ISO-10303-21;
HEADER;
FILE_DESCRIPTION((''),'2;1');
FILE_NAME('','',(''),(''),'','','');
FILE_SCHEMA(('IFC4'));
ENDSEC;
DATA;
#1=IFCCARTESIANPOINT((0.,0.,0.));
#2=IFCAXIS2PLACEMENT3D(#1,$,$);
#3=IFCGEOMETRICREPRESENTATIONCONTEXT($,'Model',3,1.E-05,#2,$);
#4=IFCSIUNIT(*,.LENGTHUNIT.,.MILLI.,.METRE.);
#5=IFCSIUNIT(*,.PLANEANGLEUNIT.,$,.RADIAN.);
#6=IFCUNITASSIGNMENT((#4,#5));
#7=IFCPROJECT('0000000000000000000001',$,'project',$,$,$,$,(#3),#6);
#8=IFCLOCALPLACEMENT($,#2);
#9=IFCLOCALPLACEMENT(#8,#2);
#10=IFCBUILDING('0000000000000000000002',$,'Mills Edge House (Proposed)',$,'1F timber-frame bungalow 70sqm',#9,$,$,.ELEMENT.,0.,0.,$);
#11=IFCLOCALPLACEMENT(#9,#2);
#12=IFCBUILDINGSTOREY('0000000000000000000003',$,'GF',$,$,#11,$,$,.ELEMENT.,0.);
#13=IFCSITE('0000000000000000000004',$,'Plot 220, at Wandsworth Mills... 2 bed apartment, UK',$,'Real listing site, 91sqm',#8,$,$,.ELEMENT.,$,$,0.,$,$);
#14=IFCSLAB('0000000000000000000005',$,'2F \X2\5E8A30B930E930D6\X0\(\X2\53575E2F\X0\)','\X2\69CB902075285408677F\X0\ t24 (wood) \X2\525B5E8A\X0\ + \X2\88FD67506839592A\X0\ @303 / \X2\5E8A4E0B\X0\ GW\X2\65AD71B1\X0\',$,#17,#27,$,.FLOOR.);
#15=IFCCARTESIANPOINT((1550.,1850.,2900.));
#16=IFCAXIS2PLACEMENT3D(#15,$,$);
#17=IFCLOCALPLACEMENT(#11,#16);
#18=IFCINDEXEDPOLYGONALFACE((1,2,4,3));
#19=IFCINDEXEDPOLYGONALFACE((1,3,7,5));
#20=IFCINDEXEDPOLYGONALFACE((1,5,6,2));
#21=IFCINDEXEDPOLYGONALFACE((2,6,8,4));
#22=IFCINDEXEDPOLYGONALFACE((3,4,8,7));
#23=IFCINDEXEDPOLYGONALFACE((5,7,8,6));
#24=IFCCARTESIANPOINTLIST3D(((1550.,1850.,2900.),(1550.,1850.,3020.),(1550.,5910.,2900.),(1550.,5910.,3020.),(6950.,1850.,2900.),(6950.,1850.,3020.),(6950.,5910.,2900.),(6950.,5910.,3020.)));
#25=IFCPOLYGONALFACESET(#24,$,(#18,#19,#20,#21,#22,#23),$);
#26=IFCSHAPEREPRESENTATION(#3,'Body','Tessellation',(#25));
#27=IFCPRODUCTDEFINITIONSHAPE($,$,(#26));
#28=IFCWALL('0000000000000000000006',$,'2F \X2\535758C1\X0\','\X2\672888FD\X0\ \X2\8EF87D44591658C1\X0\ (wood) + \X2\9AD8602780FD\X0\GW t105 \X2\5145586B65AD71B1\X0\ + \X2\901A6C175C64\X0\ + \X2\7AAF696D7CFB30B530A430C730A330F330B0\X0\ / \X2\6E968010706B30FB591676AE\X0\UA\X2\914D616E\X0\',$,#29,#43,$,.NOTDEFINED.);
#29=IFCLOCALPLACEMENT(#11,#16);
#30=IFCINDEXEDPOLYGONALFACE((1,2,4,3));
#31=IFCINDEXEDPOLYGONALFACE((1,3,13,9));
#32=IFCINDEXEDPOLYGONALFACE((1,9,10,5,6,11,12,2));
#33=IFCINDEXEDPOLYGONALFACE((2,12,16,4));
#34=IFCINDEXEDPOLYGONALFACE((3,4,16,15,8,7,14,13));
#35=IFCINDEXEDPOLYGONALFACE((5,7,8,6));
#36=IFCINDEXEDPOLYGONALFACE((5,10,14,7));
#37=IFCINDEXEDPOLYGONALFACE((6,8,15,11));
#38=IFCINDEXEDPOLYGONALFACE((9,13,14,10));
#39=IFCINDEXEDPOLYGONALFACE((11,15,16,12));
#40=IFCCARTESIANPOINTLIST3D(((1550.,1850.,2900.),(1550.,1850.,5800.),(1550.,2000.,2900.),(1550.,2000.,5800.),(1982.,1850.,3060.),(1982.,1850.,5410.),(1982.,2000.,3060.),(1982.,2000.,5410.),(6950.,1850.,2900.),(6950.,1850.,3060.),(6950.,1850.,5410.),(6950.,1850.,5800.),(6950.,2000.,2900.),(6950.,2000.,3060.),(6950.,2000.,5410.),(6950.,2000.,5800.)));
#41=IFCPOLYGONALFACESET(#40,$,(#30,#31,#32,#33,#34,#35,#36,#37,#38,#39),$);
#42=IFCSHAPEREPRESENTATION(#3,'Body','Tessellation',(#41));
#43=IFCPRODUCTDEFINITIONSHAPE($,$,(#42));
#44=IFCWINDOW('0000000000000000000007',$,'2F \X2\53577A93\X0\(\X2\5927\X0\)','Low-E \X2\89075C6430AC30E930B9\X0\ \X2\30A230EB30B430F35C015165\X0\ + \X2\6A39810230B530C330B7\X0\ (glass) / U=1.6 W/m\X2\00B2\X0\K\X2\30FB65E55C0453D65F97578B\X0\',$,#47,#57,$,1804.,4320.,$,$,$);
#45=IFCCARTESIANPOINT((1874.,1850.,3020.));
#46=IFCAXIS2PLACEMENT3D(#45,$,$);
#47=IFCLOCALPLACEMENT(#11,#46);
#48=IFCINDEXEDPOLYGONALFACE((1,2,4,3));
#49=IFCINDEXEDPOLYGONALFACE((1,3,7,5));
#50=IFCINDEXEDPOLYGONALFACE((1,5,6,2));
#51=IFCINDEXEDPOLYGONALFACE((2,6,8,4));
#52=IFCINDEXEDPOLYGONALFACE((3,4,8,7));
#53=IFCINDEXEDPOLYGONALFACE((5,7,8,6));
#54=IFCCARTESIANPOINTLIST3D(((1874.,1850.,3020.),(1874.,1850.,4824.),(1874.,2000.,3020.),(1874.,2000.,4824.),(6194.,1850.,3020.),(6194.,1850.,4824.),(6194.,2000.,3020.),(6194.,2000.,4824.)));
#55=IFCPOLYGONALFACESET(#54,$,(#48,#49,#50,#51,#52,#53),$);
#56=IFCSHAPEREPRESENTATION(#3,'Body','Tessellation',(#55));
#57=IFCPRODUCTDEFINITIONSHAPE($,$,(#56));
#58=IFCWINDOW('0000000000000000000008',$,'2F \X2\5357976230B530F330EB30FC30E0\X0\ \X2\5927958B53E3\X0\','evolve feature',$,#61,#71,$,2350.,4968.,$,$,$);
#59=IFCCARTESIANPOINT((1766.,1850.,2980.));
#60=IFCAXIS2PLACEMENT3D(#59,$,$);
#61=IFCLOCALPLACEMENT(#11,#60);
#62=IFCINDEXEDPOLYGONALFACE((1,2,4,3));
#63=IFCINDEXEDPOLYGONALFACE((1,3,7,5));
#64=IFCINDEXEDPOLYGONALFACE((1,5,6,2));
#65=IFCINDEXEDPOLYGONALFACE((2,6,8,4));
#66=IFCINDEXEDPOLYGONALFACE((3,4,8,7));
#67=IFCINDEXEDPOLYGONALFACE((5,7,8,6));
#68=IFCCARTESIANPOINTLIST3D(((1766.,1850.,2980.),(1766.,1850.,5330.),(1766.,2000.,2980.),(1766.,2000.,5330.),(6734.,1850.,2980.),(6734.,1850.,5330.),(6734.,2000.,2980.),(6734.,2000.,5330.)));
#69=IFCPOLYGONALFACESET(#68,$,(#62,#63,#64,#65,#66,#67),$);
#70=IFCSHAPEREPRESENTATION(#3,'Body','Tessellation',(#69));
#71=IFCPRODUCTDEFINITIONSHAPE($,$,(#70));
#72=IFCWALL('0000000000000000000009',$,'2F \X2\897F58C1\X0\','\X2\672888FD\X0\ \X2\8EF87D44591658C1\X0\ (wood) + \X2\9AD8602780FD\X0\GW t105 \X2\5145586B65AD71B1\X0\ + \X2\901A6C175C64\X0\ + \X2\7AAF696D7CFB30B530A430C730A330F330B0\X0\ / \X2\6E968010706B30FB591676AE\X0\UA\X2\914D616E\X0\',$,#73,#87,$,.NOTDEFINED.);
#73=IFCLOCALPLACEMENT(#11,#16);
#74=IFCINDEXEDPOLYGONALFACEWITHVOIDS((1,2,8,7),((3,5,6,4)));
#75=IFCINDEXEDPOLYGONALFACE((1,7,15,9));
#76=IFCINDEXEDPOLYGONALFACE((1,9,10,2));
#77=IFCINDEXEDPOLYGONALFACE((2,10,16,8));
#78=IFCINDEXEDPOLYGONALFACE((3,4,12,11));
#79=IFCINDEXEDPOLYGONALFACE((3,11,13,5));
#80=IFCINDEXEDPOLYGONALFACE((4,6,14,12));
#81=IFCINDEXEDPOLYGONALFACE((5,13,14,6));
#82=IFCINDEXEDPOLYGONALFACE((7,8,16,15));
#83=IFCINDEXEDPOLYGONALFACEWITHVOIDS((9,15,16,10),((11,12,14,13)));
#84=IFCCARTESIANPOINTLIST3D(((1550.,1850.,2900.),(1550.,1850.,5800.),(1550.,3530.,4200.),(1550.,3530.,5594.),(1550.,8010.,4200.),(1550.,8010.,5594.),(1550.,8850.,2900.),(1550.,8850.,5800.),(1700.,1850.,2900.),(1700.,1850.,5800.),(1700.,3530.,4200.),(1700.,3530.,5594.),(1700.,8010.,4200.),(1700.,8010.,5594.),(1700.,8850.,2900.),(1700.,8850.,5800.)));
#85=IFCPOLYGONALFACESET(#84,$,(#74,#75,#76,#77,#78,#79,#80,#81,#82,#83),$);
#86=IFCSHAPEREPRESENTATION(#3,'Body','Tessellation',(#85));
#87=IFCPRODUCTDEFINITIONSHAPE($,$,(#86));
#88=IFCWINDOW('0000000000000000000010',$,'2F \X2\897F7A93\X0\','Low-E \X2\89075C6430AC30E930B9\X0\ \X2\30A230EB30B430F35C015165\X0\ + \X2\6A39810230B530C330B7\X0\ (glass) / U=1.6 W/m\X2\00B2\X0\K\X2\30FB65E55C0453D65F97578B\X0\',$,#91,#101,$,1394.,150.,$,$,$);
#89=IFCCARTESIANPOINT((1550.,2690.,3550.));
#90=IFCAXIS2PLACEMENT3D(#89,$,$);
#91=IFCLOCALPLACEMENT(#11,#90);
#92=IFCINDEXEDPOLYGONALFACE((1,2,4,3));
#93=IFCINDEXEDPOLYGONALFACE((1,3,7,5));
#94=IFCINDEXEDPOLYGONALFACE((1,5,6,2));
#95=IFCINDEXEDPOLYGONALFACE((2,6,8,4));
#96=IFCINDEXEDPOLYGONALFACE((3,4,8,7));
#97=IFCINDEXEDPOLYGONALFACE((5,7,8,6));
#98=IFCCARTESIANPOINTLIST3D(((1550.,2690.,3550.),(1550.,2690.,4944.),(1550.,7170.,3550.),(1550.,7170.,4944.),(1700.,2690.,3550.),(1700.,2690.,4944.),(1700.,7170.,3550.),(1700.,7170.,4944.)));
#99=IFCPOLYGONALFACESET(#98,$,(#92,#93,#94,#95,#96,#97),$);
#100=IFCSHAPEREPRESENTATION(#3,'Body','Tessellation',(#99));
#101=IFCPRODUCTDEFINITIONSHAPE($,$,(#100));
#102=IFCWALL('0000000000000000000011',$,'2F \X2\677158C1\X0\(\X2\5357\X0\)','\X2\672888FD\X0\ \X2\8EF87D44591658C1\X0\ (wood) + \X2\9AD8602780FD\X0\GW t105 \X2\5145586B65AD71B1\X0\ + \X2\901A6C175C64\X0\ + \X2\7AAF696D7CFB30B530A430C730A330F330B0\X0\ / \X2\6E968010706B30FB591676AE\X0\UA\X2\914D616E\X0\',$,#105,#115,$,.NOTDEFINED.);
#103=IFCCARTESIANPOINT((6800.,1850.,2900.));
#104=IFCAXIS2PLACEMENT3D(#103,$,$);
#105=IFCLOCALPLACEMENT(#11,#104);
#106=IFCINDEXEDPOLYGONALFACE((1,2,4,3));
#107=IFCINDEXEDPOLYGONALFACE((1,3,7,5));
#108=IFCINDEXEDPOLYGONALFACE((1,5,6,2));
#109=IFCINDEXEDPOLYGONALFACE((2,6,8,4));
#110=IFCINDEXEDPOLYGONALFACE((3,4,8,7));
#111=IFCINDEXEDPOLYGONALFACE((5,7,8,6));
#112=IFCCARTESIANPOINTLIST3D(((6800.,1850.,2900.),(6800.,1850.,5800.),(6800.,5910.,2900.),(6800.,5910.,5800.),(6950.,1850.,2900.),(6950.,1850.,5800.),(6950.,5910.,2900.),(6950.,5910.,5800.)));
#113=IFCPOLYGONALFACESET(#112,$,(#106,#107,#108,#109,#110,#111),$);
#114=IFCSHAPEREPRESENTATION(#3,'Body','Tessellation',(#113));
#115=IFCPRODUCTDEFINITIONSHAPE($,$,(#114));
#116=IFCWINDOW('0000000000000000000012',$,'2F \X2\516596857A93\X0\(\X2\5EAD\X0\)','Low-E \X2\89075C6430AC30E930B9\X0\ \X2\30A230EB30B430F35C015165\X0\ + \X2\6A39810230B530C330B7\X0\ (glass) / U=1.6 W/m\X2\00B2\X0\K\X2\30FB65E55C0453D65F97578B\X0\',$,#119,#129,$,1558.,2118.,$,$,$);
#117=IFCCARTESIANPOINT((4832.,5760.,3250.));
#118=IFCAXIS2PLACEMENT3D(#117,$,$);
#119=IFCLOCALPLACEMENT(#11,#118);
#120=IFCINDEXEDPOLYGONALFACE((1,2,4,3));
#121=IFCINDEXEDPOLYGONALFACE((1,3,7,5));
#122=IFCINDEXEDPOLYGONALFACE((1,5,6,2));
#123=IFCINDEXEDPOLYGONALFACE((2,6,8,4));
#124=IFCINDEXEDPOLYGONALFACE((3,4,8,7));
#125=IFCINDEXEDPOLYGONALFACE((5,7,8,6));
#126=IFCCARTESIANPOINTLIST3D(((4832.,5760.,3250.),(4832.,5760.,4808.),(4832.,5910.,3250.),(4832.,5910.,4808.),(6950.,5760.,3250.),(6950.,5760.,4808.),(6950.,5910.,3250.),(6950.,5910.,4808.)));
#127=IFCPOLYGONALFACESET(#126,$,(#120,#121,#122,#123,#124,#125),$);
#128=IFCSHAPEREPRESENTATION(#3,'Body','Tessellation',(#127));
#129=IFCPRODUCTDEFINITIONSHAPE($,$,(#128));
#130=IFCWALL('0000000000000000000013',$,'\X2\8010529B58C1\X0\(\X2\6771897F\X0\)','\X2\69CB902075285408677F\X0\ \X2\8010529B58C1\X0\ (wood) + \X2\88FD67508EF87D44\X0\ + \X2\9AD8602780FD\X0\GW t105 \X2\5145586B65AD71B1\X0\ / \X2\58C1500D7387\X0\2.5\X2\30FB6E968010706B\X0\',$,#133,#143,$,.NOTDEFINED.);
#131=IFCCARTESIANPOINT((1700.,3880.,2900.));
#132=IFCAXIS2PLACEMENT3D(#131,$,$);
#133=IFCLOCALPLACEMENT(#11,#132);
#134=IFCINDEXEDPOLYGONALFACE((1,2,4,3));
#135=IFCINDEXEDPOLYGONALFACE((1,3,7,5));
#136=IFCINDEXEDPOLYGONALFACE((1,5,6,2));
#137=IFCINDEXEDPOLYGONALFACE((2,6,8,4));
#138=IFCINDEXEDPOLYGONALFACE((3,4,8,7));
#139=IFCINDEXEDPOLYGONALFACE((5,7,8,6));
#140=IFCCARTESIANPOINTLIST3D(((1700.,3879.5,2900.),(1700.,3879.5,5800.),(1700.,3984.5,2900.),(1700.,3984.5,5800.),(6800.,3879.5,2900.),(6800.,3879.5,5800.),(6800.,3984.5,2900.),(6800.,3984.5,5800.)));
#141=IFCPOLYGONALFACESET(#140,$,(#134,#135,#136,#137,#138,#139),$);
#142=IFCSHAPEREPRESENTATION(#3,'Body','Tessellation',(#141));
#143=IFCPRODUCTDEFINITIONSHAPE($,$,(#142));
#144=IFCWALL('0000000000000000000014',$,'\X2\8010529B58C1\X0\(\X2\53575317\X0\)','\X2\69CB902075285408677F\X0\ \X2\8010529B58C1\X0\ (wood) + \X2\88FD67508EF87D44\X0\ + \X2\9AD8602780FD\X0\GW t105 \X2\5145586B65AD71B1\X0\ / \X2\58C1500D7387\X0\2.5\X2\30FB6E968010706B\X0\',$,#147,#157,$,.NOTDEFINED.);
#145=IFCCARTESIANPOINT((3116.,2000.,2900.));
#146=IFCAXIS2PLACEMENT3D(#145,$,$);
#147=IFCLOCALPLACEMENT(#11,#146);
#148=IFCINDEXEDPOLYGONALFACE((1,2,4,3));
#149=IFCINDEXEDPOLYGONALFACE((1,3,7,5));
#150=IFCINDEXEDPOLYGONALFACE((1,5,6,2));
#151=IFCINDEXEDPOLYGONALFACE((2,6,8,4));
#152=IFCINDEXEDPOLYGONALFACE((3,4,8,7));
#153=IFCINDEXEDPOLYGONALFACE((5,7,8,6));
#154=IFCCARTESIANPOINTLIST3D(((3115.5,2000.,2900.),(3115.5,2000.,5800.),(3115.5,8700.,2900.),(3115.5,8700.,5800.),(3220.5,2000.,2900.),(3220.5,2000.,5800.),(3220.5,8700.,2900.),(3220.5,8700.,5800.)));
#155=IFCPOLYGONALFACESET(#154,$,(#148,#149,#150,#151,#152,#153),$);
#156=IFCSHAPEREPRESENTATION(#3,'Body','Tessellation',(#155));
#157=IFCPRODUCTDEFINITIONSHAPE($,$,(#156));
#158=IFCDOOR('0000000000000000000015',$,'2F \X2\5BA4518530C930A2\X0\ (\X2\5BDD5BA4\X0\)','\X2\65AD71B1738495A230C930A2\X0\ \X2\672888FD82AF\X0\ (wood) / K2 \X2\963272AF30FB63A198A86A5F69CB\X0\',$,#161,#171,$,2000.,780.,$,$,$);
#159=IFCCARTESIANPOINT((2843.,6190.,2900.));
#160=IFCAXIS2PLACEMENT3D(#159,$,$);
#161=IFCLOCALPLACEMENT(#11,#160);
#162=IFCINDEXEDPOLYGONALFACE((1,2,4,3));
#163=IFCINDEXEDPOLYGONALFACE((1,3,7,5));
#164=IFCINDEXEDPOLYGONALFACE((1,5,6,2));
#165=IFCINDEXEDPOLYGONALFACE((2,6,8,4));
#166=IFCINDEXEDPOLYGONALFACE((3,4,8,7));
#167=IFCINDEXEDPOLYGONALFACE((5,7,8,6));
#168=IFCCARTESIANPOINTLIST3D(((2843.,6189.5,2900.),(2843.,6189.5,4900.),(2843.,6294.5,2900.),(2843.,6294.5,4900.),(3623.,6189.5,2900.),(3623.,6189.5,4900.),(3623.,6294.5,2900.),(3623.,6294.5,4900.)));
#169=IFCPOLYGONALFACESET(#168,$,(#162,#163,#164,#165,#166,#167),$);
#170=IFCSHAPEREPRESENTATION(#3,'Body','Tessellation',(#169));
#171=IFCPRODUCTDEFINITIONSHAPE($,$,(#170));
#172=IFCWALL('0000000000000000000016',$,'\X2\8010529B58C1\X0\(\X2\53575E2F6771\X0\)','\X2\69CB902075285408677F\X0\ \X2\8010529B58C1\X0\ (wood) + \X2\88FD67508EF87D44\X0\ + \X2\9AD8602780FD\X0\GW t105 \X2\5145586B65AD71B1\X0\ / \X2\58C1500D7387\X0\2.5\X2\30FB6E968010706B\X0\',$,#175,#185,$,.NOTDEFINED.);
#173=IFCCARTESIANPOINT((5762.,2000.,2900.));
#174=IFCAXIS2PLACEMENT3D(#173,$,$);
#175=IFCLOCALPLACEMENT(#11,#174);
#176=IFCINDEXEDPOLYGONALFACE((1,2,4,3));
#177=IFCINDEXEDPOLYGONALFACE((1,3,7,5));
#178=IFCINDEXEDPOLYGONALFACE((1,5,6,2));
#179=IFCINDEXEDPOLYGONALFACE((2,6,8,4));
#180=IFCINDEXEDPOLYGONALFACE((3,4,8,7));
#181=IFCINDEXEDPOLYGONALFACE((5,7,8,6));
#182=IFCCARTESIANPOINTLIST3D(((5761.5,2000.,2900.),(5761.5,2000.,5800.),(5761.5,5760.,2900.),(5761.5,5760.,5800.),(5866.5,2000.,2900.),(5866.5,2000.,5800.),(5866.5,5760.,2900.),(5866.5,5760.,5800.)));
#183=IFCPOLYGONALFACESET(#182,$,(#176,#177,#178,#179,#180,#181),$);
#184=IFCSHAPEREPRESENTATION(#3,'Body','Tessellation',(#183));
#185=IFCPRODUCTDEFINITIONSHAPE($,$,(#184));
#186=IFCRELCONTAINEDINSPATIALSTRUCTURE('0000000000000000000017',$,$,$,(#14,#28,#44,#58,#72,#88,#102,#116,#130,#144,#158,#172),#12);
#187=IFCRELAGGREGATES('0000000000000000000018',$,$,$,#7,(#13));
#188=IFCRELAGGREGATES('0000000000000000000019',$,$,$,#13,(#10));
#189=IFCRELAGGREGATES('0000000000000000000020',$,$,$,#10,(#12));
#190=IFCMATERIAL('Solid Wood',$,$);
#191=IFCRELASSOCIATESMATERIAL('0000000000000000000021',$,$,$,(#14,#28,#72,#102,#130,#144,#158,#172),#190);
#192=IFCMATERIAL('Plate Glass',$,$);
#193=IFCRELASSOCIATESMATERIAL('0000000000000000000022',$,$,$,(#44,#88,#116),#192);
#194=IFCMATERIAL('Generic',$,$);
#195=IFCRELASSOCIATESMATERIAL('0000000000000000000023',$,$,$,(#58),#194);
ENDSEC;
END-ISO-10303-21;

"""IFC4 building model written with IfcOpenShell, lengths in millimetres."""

from ifc_helpers import new_model, si_unit, frame, frame_2d, origin, place, context, project, spatial, rectangle, extrude, material, element, fill, save


model = new_model("IFC4")

# Units and contexts
model_context = context("Model", 3, precision=1e-05, world=origin())
ifc_project = project(units=[si_unit("LENGTHUNIT", "METRE", prefix="MILLI"), si_unit("PLANEANGLEUNIT", "RADIAN")], contexts=[model_context])

# Site, building, storey
site_placement = place(None, origin())
site = spatial("IfcSite", under=ifc_project, at=site_placement, Name="Plot 220, at Wandsworth Mills... 2 bed apartment, UK", ObjectType="Real listing site, 91sqm", CompositionType="ELEMENT", RefElevation=0.0)
building_placement = place(site_placement, origin())
building = spatial("IfcBuilding", under=site, at=building_placement, Name="Mills Edge House (Proposed)", ObjectType="1F timber-frame bungalow 70sqm", CompositionType="ELEMENT", ElevationOfRefHeight=0.0, ElevationOfTerrain=0.0)
storey_placement = place(building_placement, origin())
storey = spatial("IfcBuildingStorey", under=building, at=storey_placement, Name="GF", CompositionType="ELEMENT", Elevation=0.0)

# Slab
ifc_material_1 = material(Name="Solid Wood")
slab_placement = place(storey_placement, frame((1550.0, 1850.0, 2900.0)))
element("IfcSlab", 1, at=slab_placement, inside=storey, material=ifc_material_1, Name="2F 床スラブ(南帯)", Description="構造用合板 t24 (wood) 剛床 + 製材根太 @303 / 床下 GW断熱", PredefinedType="FLOOR", context=model_context, shape_type="SweptSolid", body=[
    extrude(rectangle(XDim=5400.0, YDim=4060.0, at=frame_2d((2700.0, 2030.0))), frame((1550.0, 1850.0, 2900.0)), (0.0, 0.0, 1.0), 120.0),
])

# Wall, openings, windows
wall_1_placement = place(storey_placement, frame((1550.0, 1850.0, 2900.0)))
wall_1 = element("IfcWall", 2, at=wall_1_placement, inside=storey, material=ifc_material_1, Name="2F 南壁", Description="木製 軸組外壁 (wood) + 高性能GW t105 充填断熱 + 通気層 + 窯業系サイディング / 準耐火・外皮UA配慮", PredefinedType="NOTDEFINED", context=model_context, shape_type="SweptSolid", body=[
    extrude(rectangle(XDim=5400.0, YDim=150.0, at=frame_2d((2700.0, 75.0))), frame((1550.0, 1850.0, 2900.0)), (0.0, 0.0, 1.0), 2900.0),
])
opening_1_placement = place(storey_placement, frame((1874.0, 1850.0, 3020.0)))
opening_1 = element("IfcOpeningElement", 3, at=opening_1_placement, cuts=wall_1, PredefinedType="NOTDEFINED", context=model_context, shape_type="SweptSolid", body=[
    extrude(rectangle(XDim=4320.0, YDim=150.0, at=frame_2d((2160.0, 75.0))), frame((1874.0, 1850.0, 3020.0)), (0.0, 0.0, 1.0), 1804.0),
])
opening_2_placement = place(storey_placement, frame((1766.0, 1850.0, 2980.0)))
opening_2 = element("IfcOpeningElement", 4, at=opening_2_placement, cuts=wall_1, PredefinedType="NOTDEFINED", context=model_context, shape_type="SweptSolid", body=[
    extrude(rectangle(XDim=4968.0, YDim=150.0, at=frame_2d((2484.0, 75.0))), frame((1766.0, 1850.0, 2980.0)), (0.0, 0.0, 1.0), 2350.0),
])
ifc_material_2 = material(Name="Plate Glass")
window_1_placement = place(storey_placement, frame((1874.0, 1850.0, 3020.0)))
window_1 = element("IfcWindow", 5, at=window_1_placement, inside=storey, material=ifc_material_2, Name="2F 南窓(大)", Description="Low-E 複層ガラス アルゴン封入 + 樹脂サッシ (glass) / U=1.6 W/m²K・日射取得型", OverallHeight=1804.0, OverallWidth=4320.0, context=model_context, shape_type="SweptSolid", body=[
    extrude(rectangle(XDim=4320.0, YDim=150.0, at=frame_2d((2160.0, 75.0))), frame((1874.0, 1850.0, 3020.0)), (0.0, 0.0, 1.0), 1804.0),
])
fill(opening_1, window_1)
ifc_material_3 = material(Name="Generic")
window_2_placement = place(storey_placement, frame((1766.0, 1850.0, 2980.0)))
window_2 = element("IfcWindow", 6, at=window_2_placement, inside=storey, material=ifc_material_3, Name="2F 南面サンルーム 大開口", Description="evolve feature", OverallHeight=2350.0, OverallWidth=4968.0, context=model_context, shape_type="SweptSolid", body=[
    extrude(rectangle(XDim=4968.0, YDim=150.0, at=frame_2d((2484.0, 75.0))), frame((1766.0, 1850.0, 2980.0)), (0.0, 0.0, 1.0), 2350.0),
])
fill(opening_2, window_2)

# Walls, openings, windows
wall_2_placement = place(storey_placement, frame((1550.0, 1850.0, 2900.0)))
wall_2 = element("IfcWall", 7, at=wall_2_placement, inside=storey, material=ifc_material_1, Name="2F 西壁", Description="木製 軸組外壁 (wood) + 高性能GW t105 充填断熱 + 通気層 + 窯業系サイディング / 準耐火・外皮UA配慮", PredefinedType="NOTDEFINED", context=model_context, shape_type="SweptSolid", body=[
    extrude(rectangle(XDim=150.0, YDim=7000.0, at=frame_2d((75.0, 3500.0))), frame((1550.0, 1850.0, 2900.0)), (0.0, 0.0, 1.0), 2900.0),
])
opening_3_placement = place(storey_placement, frame((1550.0, 2690.0, 3550.0)))
opening_3 = element("IfcOpeningElement", 8, at=opening_3_placement, cuts=wall_2, PredefinedType="NOTDEFINED", context=model_context, shape_type="SweptSolid", body=[
    extrude(rectangle(XDim=150.0, YDim=4480.0, at=frame_2d((75.0, 2240.0))), frame((1550.0, 2690.0, 3550.0)), (0.0, 0.0, 1.0), 1394.0),
])
window_3_placement = place(storey_placement, frame((1550.0, 2690.0, 3550.0)))
window_3 = element("IfcWindow", 9, at=window_3_placement, inside=storey, material=ifc_material_2, Name="2F 西窓", Description="Low-E 複層ガラス アルゴン封入 + 樹脂サッシ (glass) / U=1.6 W/m²K・日射取得型", OverallHeight=1394.0, OverallWidth=150.0, context=model_context, shape_type="SweptSolid", body=[
    extrude(rectangle(XDim=150.0, YDim=4480.0, at=frame_2d((75.0, 2240.0))), frame((1550.0, 2690.0, 3550.0)), (0.0, 0.0, 1.0), 1394.0),
])
fill(opening_3, window_3)
wall_3_placement = place(storey_placement, frame((6800.0, 1850.0, 2900.0)))
wall_3 = element("IfcWall", 10, at=wall_3_placement, inside=storey, material=ifc_material_1, Name="2F 東壁(南)", Description="木製 軸組外壁 (wood) + 高性能GW t105 充填断熱 + 通気層 + 窯業系サイディング / 準耐火・外皮UA配慮", PredefinedType="NOTDEFINED", context=model_context, shape_type="SweptSolid", body=[
    extrude(rectangle(XDim=150.0, YDim=4060.0, at=frame_2d((75.0, 2030.0))), frame((6800.0, 1850.0, 2900.0)), (0.0, 0.0, 1.0), 2900.0),
])
opening_4_placement = place(storey_placement, frame((4832.0, 5760.0, 3250.0)))
opening_4 = element("IfcOpeningElement", 11, at=opening_4_placement, cuts=wall_3, PredefinedType="NOTDEFINED", context=model_context, shape_type="SweptSolid", body=[
    extrude(rectangle(XDim=2118.0, YDim=150.0, at=frame_2d((1059.0, 75.0))), frame((4832.0, 5760.0, 3250.0)), (0.0, 0.0, 1.0), 1558.0),
])
window_4_placement = place(storey_placement, frame((4832.0, 5760.0, 3250.0)))
window_4 = element("IfcWindow", 12, at=window_4_placement, inside=storey, material=ifc_material_2, Name="2F 入隅窓(庭)", Description="Low-E 複層ガラス アルゴン封入 + 樹脂サッシ (glass) / U=1.6 W/m²K・日射取得型", OverallHeight=1558.0, OverallWidth=2118.0, context=model_context, shape_type="SweptSolid", body=[
    extrude(rectangle(XDim=2118.0, YDim=150.0, at=frame_2d((1059.0, 75.0))), frame((4832.0, 5760.0, 3250.0)), (0.0, 0.0, 1.0), 1558.0),
])
fill(opening_4, window_4)

# Wall
wall_4_placement = place(storey_placement, frame((1700.0, 3880.0, 2900.0)))
element("IfcWall", 13, at=wall_4_placement, inside=storey, material=ifc_material_1, Name="耐力壁(東西)", Description="構造用合板 耐力壁 (wood) + 製材軸組 + 高性能GW t105 充填断熱 / 壁倍率2.5・準耐火", PredefinedType="NOTDEFINED", context=model_context, shape_type="SweptSolid", body=[
    extrude(rectangle(XDim=5100.0, YDim=105.0, at=frame_2d((2550.0, 52.0))), frame((1700.0, 3880.0, 2900.0)), (0.0, 0.0, 1.0), 2900.0),
])

# Wall, opening, door
wall_5_placement = place(storey_placement, frame((3116.0, 2000.0, 2900.0)))
wall_5 = element("IfcWall", 14, at=wall_5_placement, inside=storey, material=ifc_material_1, Name="耐力壁(南北)", Description="構造用合板 耐力壁 (wood) + 製材軸組 + 高性能GW t105 充填断熱 / 壁倍率2.5・準耐火", PredefinedType="NOTDEFINED", context=model_context, shape_type="SweptSolid", body=[
    extrude(rectangle(XDim=105.0, YDim=6700.0, at=frame_2d((52.0, 3350.0))), frame((3116.0, 2000.0, 2900.0)), (0.0, 0.0, 1.0), 2900.0),
])
opening_5_placement = place(storey_placement, frame((2843.0, 6190.0, 2900.0)))
opening_5 = element("IfcOpeningElement", 15, at=opening_5_placement, cuts=wall_5, PredefinedType="NOTDEFINED", context=model_context, shape_type="SweptSolid", body=[
    extrude(rectangle(XDim=780.0, YDim=105.0, at=frame_2d((390.0, 52.0))), frame((2843.0, 6190.0, 2900.0)), (0.0, 0.0, 1.0), 2000.0),
])
door_placement = place(storey_placement, frame((2843.0, 6190.0, 2900.0)))
door = element("IfcDoor", 16, at=door_placement, inside=storey, material=ifc_material_1, Name="2F 室内ドア (寝室)", Description="断熱玄関ドア 木製芯 (wood) / K2 防犯・採風機構", OverallHeight=2000.0, OverallWidth=780.0, context=model_context, shape_type="SweptSolid", body=[
    extrude(rectangle(XDim=780.0, YDim=105.0, at=frame_2d((390.0, 52.0))), frame((2843.0, 6190.0, 2900.0)), (0.0, 0.0, 1.0), 2000.0),
])
fill(opening_5, door)

# Wall
wall_6_placement = place(storey_placement, frame((5762.0, 2000.0, 2900.0)))
element("IfcWall", 17, at=wall_6_placement, inside=storey, material=ifc_material_1, Name="耐力壁(南帯東)", Description="構造用合板 耐力壁 (wood) + 製材軸組 + 高性能GW t105 充填断熱 / 壁倍率2.5・準耐火", PredefinedType="NOTDEFINED", context=model_context, shape_type="SweptSolid", body=[
    extrude(rectangle(XDim=105.0, YDim=3760.0, at=frame_2d((52.0, 1880.0))), frame((5762.0, 2000.0, 2900.0)), (0.0, 0.0, 1.0), 2900.0),
])

save(model, "model.ifc")
